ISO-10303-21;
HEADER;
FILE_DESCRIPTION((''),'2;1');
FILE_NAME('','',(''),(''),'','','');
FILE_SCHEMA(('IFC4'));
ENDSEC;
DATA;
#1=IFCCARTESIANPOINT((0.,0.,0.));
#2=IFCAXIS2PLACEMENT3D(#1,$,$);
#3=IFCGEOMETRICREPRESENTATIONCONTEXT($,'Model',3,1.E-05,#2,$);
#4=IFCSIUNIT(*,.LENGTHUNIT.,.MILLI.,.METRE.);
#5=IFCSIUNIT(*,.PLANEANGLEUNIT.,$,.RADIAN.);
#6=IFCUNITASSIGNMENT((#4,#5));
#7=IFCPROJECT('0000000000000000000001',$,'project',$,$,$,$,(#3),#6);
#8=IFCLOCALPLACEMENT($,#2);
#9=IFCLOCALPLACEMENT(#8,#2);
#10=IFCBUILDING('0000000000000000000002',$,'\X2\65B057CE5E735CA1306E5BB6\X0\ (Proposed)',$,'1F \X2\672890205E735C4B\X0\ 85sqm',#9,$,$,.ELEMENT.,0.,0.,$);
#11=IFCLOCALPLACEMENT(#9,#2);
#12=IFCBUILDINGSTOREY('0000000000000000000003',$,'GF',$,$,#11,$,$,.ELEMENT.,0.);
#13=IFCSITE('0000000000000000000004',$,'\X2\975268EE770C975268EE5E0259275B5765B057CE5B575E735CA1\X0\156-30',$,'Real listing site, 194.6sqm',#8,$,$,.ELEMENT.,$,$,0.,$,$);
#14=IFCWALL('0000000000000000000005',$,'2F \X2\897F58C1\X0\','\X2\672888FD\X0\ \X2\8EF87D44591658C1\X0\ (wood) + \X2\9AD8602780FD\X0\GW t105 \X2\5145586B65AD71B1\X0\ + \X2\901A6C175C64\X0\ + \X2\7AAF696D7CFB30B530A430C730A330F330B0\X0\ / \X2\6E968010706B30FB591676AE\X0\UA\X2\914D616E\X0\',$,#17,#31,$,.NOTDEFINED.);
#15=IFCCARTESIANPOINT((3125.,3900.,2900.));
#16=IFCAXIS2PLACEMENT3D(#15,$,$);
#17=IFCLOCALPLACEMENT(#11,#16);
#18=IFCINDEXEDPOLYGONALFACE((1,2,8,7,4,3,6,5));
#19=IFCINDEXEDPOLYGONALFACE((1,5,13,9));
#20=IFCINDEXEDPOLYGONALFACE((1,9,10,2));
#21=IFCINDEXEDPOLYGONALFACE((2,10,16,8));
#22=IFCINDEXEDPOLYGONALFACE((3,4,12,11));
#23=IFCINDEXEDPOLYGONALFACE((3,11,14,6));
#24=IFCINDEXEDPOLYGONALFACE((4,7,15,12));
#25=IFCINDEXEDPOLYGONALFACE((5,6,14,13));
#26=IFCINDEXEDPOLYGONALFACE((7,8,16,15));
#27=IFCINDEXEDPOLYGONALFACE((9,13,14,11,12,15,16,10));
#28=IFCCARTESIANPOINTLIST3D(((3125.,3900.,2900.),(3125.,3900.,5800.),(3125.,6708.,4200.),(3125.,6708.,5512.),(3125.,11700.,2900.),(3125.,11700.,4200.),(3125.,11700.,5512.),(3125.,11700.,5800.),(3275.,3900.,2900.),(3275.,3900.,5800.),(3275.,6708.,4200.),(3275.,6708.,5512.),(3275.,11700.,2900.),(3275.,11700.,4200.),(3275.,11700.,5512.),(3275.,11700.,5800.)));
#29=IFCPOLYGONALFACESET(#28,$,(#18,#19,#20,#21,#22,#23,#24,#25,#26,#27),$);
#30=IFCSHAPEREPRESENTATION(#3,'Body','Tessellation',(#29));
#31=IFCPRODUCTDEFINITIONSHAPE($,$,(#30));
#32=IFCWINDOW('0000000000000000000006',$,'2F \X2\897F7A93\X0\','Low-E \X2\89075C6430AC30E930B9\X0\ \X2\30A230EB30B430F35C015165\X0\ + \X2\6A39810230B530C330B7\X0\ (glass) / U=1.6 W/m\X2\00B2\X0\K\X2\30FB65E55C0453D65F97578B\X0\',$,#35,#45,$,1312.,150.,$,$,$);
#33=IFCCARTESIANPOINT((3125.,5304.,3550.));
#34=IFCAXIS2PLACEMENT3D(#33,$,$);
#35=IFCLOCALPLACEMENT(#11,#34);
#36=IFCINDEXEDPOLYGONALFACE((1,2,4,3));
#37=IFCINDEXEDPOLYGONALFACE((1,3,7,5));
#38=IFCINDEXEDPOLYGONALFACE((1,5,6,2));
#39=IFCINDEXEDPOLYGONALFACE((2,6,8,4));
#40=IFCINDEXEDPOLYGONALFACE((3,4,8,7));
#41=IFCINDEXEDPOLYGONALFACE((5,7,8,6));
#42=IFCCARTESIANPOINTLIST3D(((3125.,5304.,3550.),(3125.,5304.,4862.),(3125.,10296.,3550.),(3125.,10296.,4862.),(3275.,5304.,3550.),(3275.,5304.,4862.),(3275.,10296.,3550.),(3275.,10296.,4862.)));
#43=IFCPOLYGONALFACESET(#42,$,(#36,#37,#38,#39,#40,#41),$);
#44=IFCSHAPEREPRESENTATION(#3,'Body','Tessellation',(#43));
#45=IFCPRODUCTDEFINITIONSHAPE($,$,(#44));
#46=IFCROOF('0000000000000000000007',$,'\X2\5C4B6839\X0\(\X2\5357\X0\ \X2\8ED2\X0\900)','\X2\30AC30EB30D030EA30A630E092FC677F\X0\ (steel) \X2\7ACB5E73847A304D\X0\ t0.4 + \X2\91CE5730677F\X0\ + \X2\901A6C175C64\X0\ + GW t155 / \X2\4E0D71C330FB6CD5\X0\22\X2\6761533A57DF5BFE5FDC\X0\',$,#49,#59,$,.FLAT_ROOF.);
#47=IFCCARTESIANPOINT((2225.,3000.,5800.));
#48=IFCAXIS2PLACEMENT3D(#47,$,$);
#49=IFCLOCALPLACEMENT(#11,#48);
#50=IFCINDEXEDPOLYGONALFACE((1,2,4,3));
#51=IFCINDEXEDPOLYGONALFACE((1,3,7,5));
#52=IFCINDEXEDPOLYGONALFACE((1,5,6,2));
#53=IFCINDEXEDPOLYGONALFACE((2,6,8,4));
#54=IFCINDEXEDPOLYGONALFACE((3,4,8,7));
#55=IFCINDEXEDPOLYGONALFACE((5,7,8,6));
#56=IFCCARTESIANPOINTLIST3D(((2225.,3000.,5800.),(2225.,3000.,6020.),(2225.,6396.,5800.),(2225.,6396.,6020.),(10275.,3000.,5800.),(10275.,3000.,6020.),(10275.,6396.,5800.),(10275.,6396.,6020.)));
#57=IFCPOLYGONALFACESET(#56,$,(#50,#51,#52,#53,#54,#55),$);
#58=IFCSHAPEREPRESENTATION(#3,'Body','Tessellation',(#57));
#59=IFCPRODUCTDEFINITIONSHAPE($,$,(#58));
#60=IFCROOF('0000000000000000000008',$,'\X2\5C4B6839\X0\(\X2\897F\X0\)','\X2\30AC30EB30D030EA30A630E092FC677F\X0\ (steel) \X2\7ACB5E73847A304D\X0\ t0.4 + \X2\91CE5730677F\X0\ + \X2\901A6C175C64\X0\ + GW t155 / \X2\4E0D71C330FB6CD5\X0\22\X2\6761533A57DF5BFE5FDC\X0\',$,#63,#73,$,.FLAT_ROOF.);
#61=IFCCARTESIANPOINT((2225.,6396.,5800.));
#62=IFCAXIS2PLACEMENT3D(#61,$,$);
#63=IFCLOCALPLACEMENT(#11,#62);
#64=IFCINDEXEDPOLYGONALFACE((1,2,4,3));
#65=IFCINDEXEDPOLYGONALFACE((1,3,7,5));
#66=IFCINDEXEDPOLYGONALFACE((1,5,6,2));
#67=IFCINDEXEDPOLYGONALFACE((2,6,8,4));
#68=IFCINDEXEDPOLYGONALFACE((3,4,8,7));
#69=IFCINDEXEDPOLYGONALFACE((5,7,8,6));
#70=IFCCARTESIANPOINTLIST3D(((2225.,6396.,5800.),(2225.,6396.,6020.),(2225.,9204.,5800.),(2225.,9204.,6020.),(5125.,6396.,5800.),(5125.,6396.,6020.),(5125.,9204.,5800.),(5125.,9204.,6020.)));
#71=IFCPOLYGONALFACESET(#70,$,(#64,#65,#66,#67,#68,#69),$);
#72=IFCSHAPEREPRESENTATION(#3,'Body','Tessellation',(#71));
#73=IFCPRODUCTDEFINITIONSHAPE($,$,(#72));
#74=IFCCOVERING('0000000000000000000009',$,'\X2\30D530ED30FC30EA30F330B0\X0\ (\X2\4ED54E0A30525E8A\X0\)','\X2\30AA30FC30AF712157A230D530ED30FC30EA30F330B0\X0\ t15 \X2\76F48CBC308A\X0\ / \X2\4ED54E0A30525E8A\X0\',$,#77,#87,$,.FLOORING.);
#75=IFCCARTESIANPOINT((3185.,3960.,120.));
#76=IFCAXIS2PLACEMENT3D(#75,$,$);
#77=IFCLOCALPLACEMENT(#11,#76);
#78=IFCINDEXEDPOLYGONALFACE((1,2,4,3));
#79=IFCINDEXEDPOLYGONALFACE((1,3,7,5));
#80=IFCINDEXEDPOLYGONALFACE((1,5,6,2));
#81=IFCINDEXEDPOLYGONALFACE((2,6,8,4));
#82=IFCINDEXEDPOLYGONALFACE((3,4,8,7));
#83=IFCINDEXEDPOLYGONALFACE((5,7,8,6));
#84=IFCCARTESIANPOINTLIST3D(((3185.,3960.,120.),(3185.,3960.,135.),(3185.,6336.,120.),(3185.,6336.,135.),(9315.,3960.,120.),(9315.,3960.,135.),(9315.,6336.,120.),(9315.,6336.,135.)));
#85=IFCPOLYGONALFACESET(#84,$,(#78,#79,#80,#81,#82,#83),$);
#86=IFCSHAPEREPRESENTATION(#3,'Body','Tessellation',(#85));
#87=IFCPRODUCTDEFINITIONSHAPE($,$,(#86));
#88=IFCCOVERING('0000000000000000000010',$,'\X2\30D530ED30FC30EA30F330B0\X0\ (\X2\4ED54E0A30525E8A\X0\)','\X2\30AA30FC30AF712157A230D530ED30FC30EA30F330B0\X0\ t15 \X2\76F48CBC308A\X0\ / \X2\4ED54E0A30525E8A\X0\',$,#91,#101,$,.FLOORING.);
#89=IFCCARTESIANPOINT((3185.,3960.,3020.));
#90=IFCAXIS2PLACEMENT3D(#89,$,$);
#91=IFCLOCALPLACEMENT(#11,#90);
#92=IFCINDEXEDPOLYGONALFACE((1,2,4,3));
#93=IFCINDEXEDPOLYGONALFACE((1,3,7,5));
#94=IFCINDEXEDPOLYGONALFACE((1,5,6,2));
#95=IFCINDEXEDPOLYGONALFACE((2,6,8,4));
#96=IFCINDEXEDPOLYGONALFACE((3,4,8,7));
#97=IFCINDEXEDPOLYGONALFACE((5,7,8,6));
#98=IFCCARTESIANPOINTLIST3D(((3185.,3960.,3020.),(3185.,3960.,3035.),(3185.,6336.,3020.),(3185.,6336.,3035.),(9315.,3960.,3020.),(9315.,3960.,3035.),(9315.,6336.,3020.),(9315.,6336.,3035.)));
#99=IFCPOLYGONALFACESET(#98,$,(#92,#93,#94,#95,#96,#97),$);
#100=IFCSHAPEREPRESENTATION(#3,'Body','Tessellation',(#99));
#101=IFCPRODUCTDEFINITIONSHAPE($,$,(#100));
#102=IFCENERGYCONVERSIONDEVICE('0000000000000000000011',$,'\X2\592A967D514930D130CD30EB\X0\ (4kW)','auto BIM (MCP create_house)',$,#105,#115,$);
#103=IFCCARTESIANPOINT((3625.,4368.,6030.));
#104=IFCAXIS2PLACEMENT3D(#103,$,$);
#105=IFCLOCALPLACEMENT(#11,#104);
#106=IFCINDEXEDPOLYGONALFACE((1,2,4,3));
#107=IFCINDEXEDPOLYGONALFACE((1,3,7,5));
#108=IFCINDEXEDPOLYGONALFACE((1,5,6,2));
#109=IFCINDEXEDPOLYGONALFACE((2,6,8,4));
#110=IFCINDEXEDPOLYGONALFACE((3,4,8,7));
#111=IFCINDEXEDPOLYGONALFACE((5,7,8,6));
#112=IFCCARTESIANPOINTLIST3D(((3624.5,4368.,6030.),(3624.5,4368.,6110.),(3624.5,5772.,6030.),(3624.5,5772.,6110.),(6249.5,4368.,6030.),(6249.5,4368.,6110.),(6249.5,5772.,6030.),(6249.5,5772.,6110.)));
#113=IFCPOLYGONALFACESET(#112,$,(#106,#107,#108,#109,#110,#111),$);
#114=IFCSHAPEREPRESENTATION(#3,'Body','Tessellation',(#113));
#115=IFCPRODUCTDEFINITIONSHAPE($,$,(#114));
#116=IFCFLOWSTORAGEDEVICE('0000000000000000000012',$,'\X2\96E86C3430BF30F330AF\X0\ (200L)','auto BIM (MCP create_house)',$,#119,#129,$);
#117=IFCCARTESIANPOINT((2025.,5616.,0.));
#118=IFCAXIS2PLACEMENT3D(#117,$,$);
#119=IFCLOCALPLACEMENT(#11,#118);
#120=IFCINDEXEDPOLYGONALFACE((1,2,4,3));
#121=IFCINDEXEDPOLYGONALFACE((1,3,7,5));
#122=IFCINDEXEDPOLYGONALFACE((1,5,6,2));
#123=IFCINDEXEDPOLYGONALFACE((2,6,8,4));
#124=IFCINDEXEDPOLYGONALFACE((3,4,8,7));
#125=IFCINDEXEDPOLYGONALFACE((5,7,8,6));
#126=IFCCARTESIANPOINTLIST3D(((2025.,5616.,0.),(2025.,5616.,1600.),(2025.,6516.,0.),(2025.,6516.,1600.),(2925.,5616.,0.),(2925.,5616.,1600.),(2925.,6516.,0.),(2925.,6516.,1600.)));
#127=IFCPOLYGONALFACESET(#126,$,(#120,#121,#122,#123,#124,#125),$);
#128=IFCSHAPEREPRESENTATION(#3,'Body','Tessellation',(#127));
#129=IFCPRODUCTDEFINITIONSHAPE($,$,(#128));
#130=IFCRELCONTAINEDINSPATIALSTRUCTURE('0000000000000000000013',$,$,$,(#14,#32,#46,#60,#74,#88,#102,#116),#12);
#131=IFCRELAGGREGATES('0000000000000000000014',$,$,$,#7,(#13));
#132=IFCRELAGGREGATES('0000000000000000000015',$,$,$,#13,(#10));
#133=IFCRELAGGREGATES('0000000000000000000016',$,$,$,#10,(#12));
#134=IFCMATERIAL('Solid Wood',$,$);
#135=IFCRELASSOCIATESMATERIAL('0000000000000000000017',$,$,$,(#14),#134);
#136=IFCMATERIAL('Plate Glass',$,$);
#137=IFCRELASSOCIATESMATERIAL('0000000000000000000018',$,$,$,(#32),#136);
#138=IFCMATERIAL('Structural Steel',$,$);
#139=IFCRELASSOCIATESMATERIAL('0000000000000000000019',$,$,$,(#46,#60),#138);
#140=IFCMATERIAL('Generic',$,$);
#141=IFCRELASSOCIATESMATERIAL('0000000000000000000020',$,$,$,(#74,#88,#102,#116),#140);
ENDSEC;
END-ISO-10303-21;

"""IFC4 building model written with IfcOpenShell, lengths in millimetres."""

from ifc_helpers import new_model, si_unit, frame, frame_2d, origin, place, context, project, spatial, rectangle, extrude, material, element, fill, save


model = new_model("IFC4")

# Units and contexts
model_context = context("Model", 3, precision=1e-05, world=origin())
ifc_project = project(units=[si_unit("LENGTHUNIT", "METRE", prefix="MILLI"), si_unit("PLANEANGLEUNIT", "RADIAN")], contexts=[model_context])

# Site, building, storey
site_placement = place(None, origin())
site = spatial("IfcSite", under=ifc_project, at=site_placement, Name="青森県青森市大字新城字平岡156-30", ObjectType="Real listing site, 194.6sqm", CompositionType="ELEMENT", RefElevation=0.0)
building_placement = place(site_placement, origin())
building = spatial("IfcBuilding", under=site, at=building_placement, Name="新城平岡の家 (Proposed)", ObjectType="1F 木造平屋 85sqm", CompositionType="ELEMENT", ElevationOfRefHeight=0.0, ElevationOfTerrain=0.0)
storey_placement = place(building_placement, origin())
storey = spatial("IfcBuildingStorey", under=building, at=storey_placement, Name="GF", CompositionType="ELEMENT", Elevation=0.0)

# Shared definitions
ifc_material_1 = material(Name="Solid Wood")
ifc_material_2 = material(Name="Generic")

# Shared definitions
ifc_material_3 = material(Name="Plate Glass")

# Wall, opening, window
wall_1_placement = place(storey_placement, frame((3125.0, 3900.0, 2900.0)))
wall_1 = element("IfcWall", 1, at=wall_1_placement, inside=storey, material=ifc_material_1, Name="2F 西壁", Description="木製 軸組外壁 (wood) + 高性能GW t105 充填断熱 + 通気層 + 窯業系サイディング / 準耐火・外皮UA配慮", PredefinedType="NOTDEFINED", context=model_context, shape_type="SweptSolid", body=[
    extrude(rectangle(XDim=150.0, YDim=7800.0, at=frame_2d((75.0, 3900.0))), frame((3125.0, 3900.0, 2900.0)), (0.0, 0.0, 1.0), 2900.0),
])
opening_1_placement = place(storey_placement, frame((3125.0, 5304.0, 3550.0)))
opening_1 = element("IfcOpeningElement", 2, at=opening_1_placement, cuts=wall_1, PredefinedType="NOTDEFINED", context=model_context, shape_type="SweptSolid", body=[
    extrude(rectangle(XDim=150.0, YDim=4992.0, at=frame_2d((75.0, 2496.0))), frame((3125.0, 5304.0, 3550.0)), (0.0, 0.0, 1.0), 1312.0),
])
window_1_placement = place(storey_placement, frame((3125.0, 5304.0, 3550.0)))
window_1 = element("IfcWindow", 3, at=window_1_placement, inside=storey, material=ifc_material_3, Name="2F 西窓", Description="Low-E 複層ガラス アルゴン封入 + 樹脂サッシ (glass) / U=1.6 W/m²K・日射取得型", OverallHeight=1312.0, OverallWidth=150.0, context=model_context, shape_type="SweptSolid", body=[
    extrude(rectangle(XDim=150.0, YDim=4992.0, at=frame_2d((75.0, 2496.0))), frame((3125.0, 5304.0, 3550.0)), (0.0, 0.0, 1.0), 1312.0),
])
fill(opening_1, window_1)

# Roofs
ifc_material_4 = material(Name="Structural Steel")
roof_1_placement = place(storey_placement, frame((2225.0, 3000.0, 5800.0)))
element("IfcRoof", 4, at=roof_1_placement, inside=storey, material=ifc_material_4, Name="屋根(南 軒900)", Description="ガルバリウム鋼板 (steel) 立平葺き t0.4 + 野地板 + 通気層 + GW t155 / 不燃・法22条区域対応", PredefinedType="FLAT_ROOF", context=model_context, shape_type="SweptSolid", body=[
    extrude(rectangle(XDim=8050.0, YDim=3396.0, at=frame_2d((4025.0, 1698.0))), frame((2225.0, 3000.0, 5800.0)), (0.0, 0.0, 1.0), 220.0),
])
roof_2_placement = place(storey_placement, frame((2225.0, 6396.0, 5800.0)))
element("IfcRoof", 5, at=roof_2_placement, inside=storey, material=ifc_material_4, Name="屋根(西)", Description="ガルバリウム鋼板 (steel) 立平葺き t0.4 + 野地板 + 通気層 + GW t155 / 不燃・法22条区域対応", PredefinedType="FLAT_ROOF", context=model_context, shape_type="SweptSolid", body=[
    extrude(rectangle(XDim=2900.0, YDim=2808.0, at=frame_2d((1450.0, 1404.0))), frame((2225.0, 6396.0, 5800.0)), (0.0, 0.0, 1.0), 220.0),
])

# Coverings
covering_1_placement = place(storey_placement, frame((3185.0, 3960.0, 120.0)))
element("IfcCovering", 6, at=covering_1_placement, inside=storey, material=ifc_material_2, Name="フローリング (仕上げ床)", Description="オーク無垢フローリング t15 直貼り / 仕上げ床", PredefinedType="FLOORING", context=model_context, shape_type="SweptSolid", body=[
    extrude(rectangle(XDim=6130.0, YDim=2376.0, at=frame_2d((3065.0, 1188.0))), frame((3185.0, 3960.0, 120.0)), (0.0, 0.0, 1.0), 15.0),
])
covering_2_placement = place(storey_placement, frame((3185.0, 3960.0, 3020.0)))
element("IfcCovering", 7, at=covering_2_placement, inside=storey, material=ifc_material_2, Name="フローリング (仕上げ床)", Description="オーク無垢フローリング t15 直貼り / 仕上げ床", PredefinedType="FLOORING", context=model_context, shape_type="SweptSolid", body=[
    extrude(rectangle(XDim=6130.0, YDim=2376.0, at=frame_2d((3065.0, 1188.0))), frame((3185.0, 3960.0, 3020.0)), (0.0, 0.0, 1.0), 15.0),
])

# Energy conversion device
energy_conversion_device_placement = place(storey_placement, frame((3625.0, 4368.0, 6030.0)))
element("IfcEnergyConversionDevice", 8, at=energy_conversion_device_placement, inside=storey, material=ifc_material_2, Name="太陽光パネル (4kW)", Description="auto BIM (MCP create_house)", context=model_context, shape_type="SweptSolid", body=[
    extrude(rectangle(XDim=2625.0, YDim=1404.0, at=frame_2d((1312.0, 702.0))), frame((3625.0, 4368.0, 6030.0)), (0.0, 0.0, 1.0), 80.0),
])

# Flow storage device
flow_storage_device_placement = place(storey_placement, frame((2025.0, 5616.0, 0.0)))
element("IfcFlowStorageDevice", 9, at=flow_storage_device_placement, inside=storey, material=ifc_material_2, Name="雨水タンク (200L)", Description="auto BIM (MCP create_house)", context=model_context, shape_type="SweptSolid", body=[
    extrude(rectangle(XDim=900.0, YDim=900.0, at=frame_2d((450.0, 450.0))), frame((2025.0, 5616.0, 0.0)), (0.0, 0.0, 1.0), 1600.0),
])

save(model, "model.ifc")
